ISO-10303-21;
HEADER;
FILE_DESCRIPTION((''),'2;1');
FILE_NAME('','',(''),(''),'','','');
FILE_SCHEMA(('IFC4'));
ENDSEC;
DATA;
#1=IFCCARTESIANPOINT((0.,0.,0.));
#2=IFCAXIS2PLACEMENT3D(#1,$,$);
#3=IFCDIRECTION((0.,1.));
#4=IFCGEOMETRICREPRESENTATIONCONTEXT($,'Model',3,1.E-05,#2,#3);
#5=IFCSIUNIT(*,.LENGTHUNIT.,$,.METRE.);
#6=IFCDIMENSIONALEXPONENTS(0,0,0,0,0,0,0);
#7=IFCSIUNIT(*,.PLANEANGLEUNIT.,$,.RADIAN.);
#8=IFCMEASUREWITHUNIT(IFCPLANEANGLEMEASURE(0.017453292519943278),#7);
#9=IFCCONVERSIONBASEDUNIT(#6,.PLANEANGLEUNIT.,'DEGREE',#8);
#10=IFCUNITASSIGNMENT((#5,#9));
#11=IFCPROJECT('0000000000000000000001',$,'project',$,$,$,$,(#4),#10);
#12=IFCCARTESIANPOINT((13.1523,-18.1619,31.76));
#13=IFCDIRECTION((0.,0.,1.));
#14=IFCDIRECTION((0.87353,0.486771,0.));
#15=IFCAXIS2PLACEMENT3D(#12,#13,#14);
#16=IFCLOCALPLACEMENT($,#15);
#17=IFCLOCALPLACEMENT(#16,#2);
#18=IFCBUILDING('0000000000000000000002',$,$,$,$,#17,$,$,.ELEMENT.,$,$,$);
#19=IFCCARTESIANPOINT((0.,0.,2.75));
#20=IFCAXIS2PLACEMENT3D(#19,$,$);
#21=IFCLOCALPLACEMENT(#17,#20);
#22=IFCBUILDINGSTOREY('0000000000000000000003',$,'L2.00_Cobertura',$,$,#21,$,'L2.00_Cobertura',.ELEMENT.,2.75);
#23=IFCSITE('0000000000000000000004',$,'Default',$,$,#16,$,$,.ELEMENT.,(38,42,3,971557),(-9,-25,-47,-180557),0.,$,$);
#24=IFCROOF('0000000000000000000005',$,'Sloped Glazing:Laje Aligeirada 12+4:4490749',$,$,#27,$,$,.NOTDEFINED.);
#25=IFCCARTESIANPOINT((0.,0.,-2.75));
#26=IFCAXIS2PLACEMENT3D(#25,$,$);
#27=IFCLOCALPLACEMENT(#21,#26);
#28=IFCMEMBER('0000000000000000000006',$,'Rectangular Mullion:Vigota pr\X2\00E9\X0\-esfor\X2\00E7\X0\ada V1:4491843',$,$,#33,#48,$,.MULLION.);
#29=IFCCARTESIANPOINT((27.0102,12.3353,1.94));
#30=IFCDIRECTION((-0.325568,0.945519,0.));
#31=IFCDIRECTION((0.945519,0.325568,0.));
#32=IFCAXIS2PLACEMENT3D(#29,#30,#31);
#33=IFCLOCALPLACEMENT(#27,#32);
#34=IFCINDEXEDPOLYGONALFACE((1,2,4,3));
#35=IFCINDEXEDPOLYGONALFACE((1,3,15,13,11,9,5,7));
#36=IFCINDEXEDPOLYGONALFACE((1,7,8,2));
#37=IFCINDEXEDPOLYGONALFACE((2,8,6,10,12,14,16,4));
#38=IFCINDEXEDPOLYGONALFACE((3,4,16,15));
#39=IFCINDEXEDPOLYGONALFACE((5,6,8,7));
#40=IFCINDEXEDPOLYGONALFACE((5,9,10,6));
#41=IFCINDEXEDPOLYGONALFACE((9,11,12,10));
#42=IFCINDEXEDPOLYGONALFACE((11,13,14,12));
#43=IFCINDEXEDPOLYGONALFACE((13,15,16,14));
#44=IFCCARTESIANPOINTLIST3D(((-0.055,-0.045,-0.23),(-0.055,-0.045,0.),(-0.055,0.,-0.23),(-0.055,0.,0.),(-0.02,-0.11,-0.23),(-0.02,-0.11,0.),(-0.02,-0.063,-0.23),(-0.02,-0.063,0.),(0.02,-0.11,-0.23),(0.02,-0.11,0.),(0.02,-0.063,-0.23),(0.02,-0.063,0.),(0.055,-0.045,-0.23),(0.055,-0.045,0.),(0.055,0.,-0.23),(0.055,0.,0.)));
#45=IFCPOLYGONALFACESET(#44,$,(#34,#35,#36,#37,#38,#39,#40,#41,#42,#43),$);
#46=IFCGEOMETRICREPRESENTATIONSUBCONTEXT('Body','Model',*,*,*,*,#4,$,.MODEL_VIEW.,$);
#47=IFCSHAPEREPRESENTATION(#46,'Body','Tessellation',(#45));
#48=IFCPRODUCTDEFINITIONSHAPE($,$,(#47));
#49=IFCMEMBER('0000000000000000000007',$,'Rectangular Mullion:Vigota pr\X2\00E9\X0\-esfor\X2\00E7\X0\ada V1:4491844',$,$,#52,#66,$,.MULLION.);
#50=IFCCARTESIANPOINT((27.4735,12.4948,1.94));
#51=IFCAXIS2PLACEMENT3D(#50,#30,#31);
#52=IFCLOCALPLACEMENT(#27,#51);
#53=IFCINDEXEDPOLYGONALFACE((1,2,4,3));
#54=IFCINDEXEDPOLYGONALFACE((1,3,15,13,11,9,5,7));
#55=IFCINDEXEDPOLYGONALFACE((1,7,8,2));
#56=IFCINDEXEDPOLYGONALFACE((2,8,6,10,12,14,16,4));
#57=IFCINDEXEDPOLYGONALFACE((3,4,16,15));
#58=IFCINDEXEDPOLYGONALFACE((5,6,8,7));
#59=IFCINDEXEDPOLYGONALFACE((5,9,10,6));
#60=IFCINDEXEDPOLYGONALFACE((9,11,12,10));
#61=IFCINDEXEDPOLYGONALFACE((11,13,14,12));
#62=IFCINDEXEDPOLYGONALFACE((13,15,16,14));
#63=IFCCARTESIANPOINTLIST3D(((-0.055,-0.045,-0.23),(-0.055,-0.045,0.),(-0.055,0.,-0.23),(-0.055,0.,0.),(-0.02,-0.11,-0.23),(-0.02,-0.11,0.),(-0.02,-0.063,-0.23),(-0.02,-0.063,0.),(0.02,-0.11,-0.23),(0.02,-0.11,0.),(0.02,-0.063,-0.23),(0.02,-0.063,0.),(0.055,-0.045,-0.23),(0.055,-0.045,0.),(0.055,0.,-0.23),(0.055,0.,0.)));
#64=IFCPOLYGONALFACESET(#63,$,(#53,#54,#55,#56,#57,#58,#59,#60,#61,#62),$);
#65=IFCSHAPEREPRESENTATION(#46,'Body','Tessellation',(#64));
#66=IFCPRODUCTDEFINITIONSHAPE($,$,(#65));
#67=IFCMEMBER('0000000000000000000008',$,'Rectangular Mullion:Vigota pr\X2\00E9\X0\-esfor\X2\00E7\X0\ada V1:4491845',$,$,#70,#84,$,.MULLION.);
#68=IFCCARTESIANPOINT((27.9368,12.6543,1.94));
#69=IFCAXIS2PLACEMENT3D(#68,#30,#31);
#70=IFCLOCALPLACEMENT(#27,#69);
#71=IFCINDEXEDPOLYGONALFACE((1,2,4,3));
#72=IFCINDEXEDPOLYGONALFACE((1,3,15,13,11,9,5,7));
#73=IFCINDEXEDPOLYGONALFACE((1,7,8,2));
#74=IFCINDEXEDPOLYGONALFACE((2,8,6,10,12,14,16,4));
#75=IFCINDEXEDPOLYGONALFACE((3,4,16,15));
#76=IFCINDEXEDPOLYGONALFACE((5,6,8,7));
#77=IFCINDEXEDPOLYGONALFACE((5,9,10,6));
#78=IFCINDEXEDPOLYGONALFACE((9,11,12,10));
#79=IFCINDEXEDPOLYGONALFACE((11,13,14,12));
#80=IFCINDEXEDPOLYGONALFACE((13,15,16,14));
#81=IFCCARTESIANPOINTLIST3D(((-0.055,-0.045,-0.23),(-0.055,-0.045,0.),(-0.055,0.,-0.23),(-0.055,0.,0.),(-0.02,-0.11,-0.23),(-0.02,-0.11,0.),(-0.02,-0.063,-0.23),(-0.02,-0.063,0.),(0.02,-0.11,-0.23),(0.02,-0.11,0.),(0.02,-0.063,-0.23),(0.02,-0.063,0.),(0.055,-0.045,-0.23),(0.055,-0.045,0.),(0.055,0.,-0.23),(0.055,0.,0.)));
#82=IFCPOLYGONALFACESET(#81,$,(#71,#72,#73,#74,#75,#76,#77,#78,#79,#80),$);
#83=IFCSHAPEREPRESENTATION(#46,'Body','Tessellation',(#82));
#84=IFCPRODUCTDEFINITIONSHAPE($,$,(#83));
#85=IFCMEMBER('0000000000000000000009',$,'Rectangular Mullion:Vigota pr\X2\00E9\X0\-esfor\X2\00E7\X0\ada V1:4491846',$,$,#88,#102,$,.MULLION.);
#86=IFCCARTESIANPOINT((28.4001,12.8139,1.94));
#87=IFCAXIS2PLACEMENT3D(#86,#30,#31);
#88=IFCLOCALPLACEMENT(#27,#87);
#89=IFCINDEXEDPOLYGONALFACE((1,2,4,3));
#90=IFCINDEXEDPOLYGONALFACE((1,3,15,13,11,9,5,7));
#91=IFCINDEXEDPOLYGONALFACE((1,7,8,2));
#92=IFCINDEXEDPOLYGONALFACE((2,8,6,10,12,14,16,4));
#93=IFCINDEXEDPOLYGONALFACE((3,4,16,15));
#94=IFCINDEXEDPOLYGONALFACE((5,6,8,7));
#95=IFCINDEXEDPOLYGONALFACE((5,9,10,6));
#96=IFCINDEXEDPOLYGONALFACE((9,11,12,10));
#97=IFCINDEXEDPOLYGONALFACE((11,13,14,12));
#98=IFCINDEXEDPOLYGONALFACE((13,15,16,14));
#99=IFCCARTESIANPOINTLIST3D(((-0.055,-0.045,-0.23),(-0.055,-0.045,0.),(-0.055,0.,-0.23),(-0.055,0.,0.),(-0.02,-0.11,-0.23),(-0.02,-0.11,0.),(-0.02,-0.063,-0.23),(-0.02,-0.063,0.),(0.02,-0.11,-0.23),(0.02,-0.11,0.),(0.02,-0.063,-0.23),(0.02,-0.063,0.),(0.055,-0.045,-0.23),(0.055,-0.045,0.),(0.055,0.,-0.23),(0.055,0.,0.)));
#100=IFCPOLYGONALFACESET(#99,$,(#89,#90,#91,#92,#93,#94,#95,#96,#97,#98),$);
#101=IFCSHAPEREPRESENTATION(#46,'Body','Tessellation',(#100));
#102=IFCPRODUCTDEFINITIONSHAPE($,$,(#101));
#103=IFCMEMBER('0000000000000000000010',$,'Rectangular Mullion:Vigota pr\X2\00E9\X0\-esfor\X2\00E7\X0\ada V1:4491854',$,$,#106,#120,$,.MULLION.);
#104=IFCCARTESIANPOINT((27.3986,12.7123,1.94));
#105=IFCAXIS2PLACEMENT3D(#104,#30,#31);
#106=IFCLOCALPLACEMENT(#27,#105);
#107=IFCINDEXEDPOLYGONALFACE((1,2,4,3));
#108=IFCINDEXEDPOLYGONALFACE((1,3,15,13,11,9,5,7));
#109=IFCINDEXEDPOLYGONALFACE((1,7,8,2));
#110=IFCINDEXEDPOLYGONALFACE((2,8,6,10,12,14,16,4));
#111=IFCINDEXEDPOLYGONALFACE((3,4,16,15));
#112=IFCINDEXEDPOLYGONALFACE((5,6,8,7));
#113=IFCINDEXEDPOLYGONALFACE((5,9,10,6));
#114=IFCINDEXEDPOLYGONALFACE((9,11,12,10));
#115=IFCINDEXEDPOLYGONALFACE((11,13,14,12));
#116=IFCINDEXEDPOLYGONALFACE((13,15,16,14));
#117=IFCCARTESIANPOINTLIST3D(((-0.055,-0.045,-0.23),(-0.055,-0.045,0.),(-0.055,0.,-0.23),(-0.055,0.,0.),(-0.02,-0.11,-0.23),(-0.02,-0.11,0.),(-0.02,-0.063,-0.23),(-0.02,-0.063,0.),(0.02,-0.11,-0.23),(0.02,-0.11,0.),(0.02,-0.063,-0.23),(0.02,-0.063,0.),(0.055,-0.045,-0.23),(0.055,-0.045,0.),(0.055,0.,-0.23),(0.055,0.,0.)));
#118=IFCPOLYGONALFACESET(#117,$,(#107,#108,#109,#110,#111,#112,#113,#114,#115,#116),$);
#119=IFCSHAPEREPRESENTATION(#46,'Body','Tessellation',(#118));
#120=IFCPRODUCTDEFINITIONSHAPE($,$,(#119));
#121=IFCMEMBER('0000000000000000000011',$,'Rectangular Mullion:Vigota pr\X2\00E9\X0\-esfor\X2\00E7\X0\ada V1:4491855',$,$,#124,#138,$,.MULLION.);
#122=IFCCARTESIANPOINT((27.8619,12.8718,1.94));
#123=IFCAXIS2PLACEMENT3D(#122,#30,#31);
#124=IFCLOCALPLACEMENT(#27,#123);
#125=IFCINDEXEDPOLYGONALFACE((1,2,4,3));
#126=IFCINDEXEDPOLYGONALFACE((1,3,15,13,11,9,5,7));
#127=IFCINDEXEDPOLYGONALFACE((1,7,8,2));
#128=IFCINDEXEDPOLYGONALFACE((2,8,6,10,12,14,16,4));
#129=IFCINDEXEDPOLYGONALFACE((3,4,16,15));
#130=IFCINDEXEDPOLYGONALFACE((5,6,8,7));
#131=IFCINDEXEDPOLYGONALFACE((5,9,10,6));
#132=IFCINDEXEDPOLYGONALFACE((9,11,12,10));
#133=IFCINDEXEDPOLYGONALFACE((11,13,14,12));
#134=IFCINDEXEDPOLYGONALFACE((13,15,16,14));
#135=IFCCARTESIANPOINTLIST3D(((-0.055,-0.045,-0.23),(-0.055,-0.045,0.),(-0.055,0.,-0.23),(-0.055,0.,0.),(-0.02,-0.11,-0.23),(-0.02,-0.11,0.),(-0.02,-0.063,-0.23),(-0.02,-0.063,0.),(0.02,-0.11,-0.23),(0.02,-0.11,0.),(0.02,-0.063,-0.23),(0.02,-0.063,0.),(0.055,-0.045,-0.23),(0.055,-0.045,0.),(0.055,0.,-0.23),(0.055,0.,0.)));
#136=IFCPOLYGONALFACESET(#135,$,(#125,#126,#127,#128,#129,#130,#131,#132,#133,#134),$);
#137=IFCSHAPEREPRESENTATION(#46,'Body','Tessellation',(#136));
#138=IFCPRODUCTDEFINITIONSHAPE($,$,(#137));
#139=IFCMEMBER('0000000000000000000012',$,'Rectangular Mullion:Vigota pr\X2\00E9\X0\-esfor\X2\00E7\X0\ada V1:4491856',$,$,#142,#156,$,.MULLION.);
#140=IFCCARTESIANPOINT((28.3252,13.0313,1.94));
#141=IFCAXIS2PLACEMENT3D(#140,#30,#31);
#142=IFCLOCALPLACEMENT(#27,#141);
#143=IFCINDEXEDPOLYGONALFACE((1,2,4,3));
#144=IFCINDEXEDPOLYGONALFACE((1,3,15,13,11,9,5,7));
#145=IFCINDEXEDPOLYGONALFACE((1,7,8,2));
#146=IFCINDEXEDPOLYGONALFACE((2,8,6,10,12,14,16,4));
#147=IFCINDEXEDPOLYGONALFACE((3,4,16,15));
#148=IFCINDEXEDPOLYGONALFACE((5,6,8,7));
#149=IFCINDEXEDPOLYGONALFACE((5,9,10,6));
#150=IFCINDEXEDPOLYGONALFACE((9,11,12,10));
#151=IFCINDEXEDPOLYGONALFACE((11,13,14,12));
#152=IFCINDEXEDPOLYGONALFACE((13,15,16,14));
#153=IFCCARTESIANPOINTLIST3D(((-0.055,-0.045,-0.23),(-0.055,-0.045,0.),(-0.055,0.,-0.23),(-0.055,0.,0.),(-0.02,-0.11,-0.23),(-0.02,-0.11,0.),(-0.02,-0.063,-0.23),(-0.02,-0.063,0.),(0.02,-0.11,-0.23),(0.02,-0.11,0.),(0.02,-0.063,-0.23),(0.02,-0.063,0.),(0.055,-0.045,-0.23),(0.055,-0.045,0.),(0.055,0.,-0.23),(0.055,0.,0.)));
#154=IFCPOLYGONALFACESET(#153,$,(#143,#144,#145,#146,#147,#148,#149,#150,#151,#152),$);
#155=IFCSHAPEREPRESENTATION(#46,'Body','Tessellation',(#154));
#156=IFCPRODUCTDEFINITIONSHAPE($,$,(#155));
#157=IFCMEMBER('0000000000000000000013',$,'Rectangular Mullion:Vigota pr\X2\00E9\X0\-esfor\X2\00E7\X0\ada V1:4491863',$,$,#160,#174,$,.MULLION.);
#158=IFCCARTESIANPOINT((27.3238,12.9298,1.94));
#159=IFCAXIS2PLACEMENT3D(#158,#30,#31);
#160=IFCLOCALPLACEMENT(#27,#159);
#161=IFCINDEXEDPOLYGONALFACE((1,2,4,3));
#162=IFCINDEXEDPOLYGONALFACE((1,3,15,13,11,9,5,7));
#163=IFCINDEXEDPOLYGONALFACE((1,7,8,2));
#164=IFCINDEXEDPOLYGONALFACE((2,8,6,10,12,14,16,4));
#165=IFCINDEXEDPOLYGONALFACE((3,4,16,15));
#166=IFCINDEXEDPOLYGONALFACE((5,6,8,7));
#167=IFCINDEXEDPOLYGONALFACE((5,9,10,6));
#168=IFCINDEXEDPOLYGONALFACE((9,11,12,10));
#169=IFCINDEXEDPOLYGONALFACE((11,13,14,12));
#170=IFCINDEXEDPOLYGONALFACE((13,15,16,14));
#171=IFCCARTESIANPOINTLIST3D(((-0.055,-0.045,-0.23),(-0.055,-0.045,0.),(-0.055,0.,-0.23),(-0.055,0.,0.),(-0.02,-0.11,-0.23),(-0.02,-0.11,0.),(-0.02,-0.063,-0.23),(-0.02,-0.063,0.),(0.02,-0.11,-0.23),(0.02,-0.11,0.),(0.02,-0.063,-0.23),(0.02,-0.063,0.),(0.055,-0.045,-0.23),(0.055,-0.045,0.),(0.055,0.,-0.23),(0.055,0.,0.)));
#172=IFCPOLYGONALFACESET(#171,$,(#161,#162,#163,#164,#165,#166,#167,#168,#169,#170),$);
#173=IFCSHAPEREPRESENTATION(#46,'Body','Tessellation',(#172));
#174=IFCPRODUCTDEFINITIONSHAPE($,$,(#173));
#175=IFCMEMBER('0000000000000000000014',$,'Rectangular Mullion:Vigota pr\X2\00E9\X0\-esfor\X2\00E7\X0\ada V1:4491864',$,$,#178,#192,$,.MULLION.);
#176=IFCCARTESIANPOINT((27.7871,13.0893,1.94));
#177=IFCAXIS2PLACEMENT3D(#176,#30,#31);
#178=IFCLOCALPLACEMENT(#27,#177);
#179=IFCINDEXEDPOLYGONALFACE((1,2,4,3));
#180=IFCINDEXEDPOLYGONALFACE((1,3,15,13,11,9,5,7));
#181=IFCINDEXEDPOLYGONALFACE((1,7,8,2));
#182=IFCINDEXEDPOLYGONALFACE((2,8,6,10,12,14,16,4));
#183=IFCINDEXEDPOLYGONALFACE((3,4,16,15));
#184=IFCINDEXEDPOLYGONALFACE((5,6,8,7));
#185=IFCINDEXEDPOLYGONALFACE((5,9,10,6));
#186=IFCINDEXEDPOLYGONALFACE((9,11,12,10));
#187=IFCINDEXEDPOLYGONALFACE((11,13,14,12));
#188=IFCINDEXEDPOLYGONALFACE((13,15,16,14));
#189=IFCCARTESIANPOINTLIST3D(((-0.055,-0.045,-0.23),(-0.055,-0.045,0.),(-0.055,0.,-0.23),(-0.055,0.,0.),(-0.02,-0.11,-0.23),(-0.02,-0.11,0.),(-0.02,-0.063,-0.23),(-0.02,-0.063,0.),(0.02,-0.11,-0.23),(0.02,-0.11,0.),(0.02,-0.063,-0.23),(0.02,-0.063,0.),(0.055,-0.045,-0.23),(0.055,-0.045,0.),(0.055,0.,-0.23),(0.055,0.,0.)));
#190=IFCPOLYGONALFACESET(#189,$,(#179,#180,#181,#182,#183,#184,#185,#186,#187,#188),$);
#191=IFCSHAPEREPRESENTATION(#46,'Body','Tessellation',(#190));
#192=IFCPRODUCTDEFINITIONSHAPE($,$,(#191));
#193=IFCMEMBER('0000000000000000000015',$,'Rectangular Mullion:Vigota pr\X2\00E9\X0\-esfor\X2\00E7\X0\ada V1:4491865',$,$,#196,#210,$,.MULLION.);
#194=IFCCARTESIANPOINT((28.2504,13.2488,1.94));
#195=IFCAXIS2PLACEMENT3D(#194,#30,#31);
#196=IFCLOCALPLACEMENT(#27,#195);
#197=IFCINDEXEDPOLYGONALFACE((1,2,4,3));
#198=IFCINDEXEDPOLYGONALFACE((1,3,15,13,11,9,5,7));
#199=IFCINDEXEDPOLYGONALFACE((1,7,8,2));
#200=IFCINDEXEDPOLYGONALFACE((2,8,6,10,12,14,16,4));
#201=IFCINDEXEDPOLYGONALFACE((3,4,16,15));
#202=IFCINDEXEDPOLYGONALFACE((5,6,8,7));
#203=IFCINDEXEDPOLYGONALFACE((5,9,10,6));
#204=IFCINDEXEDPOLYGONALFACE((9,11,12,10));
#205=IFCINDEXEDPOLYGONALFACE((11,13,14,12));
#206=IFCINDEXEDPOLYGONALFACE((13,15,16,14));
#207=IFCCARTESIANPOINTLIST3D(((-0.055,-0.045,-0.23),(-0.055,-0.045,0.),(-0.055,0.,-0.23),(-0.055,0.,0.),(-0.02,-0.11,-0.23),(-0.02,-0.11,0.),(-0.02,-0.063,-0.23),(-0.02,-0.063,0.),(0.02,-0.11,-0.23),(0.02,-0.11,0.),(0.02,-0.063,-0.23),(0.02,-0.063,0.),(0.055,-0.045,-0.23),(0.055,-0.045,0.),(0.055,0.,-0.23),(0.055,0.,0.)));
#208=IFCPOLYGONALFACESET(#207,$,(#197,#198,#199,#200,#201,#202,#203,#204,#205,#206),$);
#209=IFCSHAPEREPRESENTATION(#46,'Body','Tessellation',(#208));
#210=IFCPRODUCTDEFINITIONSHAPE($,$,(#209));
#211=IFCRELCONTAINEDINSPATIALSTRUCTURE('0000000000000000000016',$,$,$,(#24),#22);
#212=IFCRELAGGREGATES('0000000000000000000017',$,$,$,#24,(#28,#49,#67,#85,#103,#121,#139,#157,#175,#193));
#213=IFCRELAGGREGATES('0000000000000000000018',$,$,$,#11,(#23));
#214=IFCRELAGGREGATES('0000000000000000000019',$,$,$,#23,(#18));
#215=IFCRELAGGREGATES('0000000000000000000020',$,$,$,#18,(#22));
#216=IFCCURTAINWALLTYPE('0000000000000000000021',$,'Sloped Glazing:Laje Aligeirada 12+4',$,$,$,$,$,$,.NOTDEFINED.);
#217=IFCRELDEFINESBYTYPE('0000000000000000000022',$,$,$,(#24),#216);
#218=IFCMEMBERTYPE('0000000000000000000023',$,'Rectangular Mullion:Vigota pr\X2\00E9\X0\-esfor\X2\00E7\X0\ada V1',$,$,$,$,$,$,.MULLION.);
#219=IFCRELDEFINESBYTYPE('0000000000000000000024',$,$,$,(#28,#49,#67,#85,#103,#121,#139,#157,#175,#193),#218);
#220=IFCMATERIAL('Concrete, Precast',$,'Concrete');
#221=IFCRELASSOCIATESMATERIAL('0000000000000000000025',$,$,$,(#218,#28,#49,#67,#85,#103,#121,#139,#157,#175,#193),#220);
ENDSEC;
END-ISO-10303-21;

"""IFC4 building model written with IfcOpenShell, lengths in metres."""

from ifc_helpers import new_model, entity, si_unit, converted_unit, direction, frame, origin, place, context, subcontext, project, spatial, indexed_curve, outline, extrude, source, transform, mapped, material, type_object, type_shapes, element, aggregate, save


model = new_model("IFC4")

# Units and contexts
model_context = context("Model", 3, precision=1e-05, world=origin(), true_north=direction((0.0, 1.0)))
body_context = subcontext(model_context, "Body", "Model", "MODEL_VIEW")
ifc_project = project(units=[si_unit("LENGTHUNIT", "METRE"), converted_unit("PLANEANGLEUNIT", "DEGREE", entity("IfcPlaneAngleMeasure", 0.017453292519943278), si_unit("PLANEANGLEUNIT", "RADIAN"), dimensions=[0, 0, 0, 0, 0, 0, 0])], contexts=[model_context])

# Site, building, storey
site_placement = place(None, frame((13.1523, -18.1619, 31.76), z_axis=(0.0, 0.0, 1.0), x_axis=(0.87353, 0.486771, 0.0)))
site = spatial("IfcSite", under=ifc_project, at=site_placement, Name="Default", CompositionType="ELEMENT", RefLatitude=(38, 42, 3, 971557), RefLongitude=(-9, -25, -47, -180557), RefElevation=0.0)
building_placement = place(site_placement, origin())
building = spatial("IfcBuilding", under=site, at=building_placement, CompositionType="ELEMENT")
storey_placement = place(building_placement, frame((0.0, 0.0, 2.75)))
storey = spatial("IfcBuildingStorey", under=building, at=storey_placement, Name="L2.00_Cobertura", LongName="L2.00_Cobertura", CompositionType="ELEMENT", Elevation=2.75)

# Roof, members
curtain_wall_type = type_object("IfcCurtainWallType", Name="Sloped Glazing:Laje Aligeirada 12+4", PredefinedType="NOTDEFINED")
roof_placement = place(storey_placement, frame((0.0, 0.0, -2.75)))
roof = element("IfcRoof", 1, at=roof_placement, inside=storey, type_object=curtain_wall_type, Name="Sloped Glazing:Laje Aligeirada 12+4:4490749", PredefinedType="NOTDEFINED")
ifc_material_1 = material(Name="Concrete, Precast", Category="Concrete")
member_type_1 = type_object("IfcMemberType", Name="Rectangular Mullion:Vigota pré-esforçada V1", PredefinedType="MULLION", material=ifc_material_1)
shared_shape_1 = source(origin(), body_context, "Body", "SweptSolid", [
    extrude(outline(indexed_curve([(-0.055, -0.0545), (0.055, -0.0545), (0.055, -0.0095), (0.02, 0.0085), (0.02, 0.0555), (-0.02, 0.0555), (-0.02, 0.0085), (-0.055, -0.0095), (-0.055, -0.0545)], self_intersect=False)), frame((0.0, -0.0545, -0.23), z_axis=(0.0, 0.0, 1.0), x_axis=(-1.0, 0.0, 0.0)), (0.0, 0.0, 1.0), 0.23),
])
type_shapes(member_type_1, [shared_shape_1])
member_1_placement = place(roof_placement, frame((27.0102, 12.3353, 1.94), z_axis=(-0.325568, 0.945519, 0.0), x_axis=(0.945519, 0.325568, 0.0)))
member_1 = element("IfcMember", 2, at=member_1_placement, type_object=member_type_1, material=ifc_material_1, Name="Rectangular Mullion:Vigota pré-esforçada V1:4491843", PredefinedType="MULLION", context=body_context, shape_type="MappedRepresentation", body=[
    mapped(shared_shape_1, transform((0.0, 0.0, 0.0), scale=1.0)),
])
member_2_placement = place(roof_placement, frame((27.4735, 12.4948, 1.94), z_axis=(-0.325568, 0.945519, 0.0), x_axis=(0.945519, 0.325568, 0.0)))
member_2 = element("IfcMember", 3, at=member_2_placement, type_object=member_type_1, material=ifc_material_1, Name="Rectangular Mullion:Vigota pré-esforçada V1:4491844", PredefinedType="MULLION", context=body_context, shape_type="MappedRepresentation", body=[
    mapped(shared_shape_1, transform((0.0, 0.0, 0.0), scale=1.0)),
])
member_3_placement = place(roof_placement, frame((27.9368, 12.6543, 1.94), z_axis=(-0.325568, 0.945519, 0.0), x_axis=(0.945519, 0.325568, 0.0)))
member_3 = element("IfcMember", 4, at=member_3_placement, type_object=member_type_1, material=ifc_material_1, Name="Rectangular Mullion:Vigota pré-esforçada V1:4491845", PredefinedType="MULLION", context=body_context, shape_type="MappedRepresentation", body=[
    mapped(shared_shape_1, transform((0.0, 0.0, 0.0), scale=1.0)),
])
member_4_placement = place(roof_placement, frame((28.4001, 12.8139, 1.94), z_axis=(-0.325568, 0.945519, 0.0), x_axis=(0.945519, 0.325568, 0.0)))
member_4 = element("IfcMember", 5, at=member_4_placement, type_object=member_type_1, material=ifc_material_1, Name="Rectangular Mullion:Vigota pré-esforçada V1:4491846", PredefinedType="MULLION", context=body_context, shape_type="MappedRepresentation", body=[
    mapped(shared_shape_1, transform((0.0, 0.0, 0.0), scale=1.0)),
])
member_5_placement = place(roof_placement, frame((27.3986, 12.7123, 1.94), z_axis=(-0.325568, 0.945519, 0.0), x_axis=(0.945519, 0.325568, 0.0)))
member_5 = element("IfcMember", 6, at=member_5_placement, type_object=member_type_1, material=ifc_material_1, Name="Rectangular Mullion:Vigota pré-esforçada V1:4491854", PredefinedType="MULLION", context=body_context, shape_type="MappedRepresentation", body=[
    mapped(shared_shape_1, transform((0.0, 0.0, 0.0), scale=1.0)),
])
member_6_placement = place(roof_placement, frame((27.8619, 12.8718, 1.94), z_axis=(-0.325568, 0.945519, 0.0), x_axis=(0.945519, 0.325568, 0.0)))
member_6 = element("IfcMember", 7, at=member_6_placement, type_object=member_type_1, material=ifc_material_1, Name="Rectangular Mullion:Vigota pré-esforçada V1:4491855", PredefinedType="MULLION", context=body_context, shape_type="MappedRepresentation", body=[
    mapped(shared_shape_1, transform((0.0, 0.0, 0.0), scale=1.0)),
])
member_7_placement = place(roof_placement, frame((28.3252, 13.0313, 1.94), z_axis=(-0.325568, 0.945519, 0.0), x_axis=(0.945519, 0.325568, 0.0)))
member_7 = element("IfcMember", 8, at=member_7_placement, type_object=member_type_1, material=ifc_material_1, Name="Rectangular Mullion:Vigota pré-esforçada V1:4491856", PredefinedType="MULLION", context=body_context, shape_type="MappedRepresentation", body=[
    mapped(shared_shape_1, transform((0.0, 0.0, 0.0), scale=1.0)),
])
member_8_placement = place(roof_placement, frame((27.3238, 12.9298, 1.94), z_axis=(-0.325568, 0.945519, 0.0), x_axis=(0.945519, 0.325568, 0.0)))
member_8 = element("IfcMember", 9, at=member_8_placement, type_object=member_type_1, material=ifc_material_1, Name="Rectangular Mullion:Vigota pré-esforçada V1:4491863", PredefinedType="MULLION", context=body_context, shape_type="MappedRepresentation", body=[
    mapped(shared_shape_1, transform((0.0, 0.0, 0.0), scale=1.0)),
])
member_9_placement = place(roof_placement, frame((27.7871, 13.0893, 1.94), z_axis=(-0.325568, 0.945519, 0.0), x_axis=(0.945519, 0.325568, 0.0)))
member_9 = element("IfcMember", 10, at=member_9_placement, type_object=member_type_1, material=ifc_material_1, Name="Rectangular Mullion:Vigota pré-esforçada V1:4491864", PredefinedType="MULLION", context=body_context, shape_type="MappedRepresentation", body=[
    mapped(shared_shape_1, transform((0.0, 0.0, 0.0), scale=1.0)),
])
member_10_placement = place(roof_placement, frame((28.2504, 13.2488, 1.94), z_axis=(-0.325568, 0.945519, 0.0), x_axis=(0.945519, 0.325568, 0.0)))
member_10 = element("IfcMember", 11, at=member_10_placement, type_object=member_type_1, material=ifc_material_1, Name="Rectangular Mullion:Vigota pré-esforçada V1:4491865", PredefinedType="MULLION", context=body_context, shape_type="MappedRepresentation", body=[
    mapped(shared_shape_1, transform((0.0, 0.0, 0.0), scale=1.0)),
])
aggregate(roof, [member_1, member_2, member_3, member_4, member_5, member_6, member_7, member_8, member_9, member_10])

save(model, "model.ifc")
